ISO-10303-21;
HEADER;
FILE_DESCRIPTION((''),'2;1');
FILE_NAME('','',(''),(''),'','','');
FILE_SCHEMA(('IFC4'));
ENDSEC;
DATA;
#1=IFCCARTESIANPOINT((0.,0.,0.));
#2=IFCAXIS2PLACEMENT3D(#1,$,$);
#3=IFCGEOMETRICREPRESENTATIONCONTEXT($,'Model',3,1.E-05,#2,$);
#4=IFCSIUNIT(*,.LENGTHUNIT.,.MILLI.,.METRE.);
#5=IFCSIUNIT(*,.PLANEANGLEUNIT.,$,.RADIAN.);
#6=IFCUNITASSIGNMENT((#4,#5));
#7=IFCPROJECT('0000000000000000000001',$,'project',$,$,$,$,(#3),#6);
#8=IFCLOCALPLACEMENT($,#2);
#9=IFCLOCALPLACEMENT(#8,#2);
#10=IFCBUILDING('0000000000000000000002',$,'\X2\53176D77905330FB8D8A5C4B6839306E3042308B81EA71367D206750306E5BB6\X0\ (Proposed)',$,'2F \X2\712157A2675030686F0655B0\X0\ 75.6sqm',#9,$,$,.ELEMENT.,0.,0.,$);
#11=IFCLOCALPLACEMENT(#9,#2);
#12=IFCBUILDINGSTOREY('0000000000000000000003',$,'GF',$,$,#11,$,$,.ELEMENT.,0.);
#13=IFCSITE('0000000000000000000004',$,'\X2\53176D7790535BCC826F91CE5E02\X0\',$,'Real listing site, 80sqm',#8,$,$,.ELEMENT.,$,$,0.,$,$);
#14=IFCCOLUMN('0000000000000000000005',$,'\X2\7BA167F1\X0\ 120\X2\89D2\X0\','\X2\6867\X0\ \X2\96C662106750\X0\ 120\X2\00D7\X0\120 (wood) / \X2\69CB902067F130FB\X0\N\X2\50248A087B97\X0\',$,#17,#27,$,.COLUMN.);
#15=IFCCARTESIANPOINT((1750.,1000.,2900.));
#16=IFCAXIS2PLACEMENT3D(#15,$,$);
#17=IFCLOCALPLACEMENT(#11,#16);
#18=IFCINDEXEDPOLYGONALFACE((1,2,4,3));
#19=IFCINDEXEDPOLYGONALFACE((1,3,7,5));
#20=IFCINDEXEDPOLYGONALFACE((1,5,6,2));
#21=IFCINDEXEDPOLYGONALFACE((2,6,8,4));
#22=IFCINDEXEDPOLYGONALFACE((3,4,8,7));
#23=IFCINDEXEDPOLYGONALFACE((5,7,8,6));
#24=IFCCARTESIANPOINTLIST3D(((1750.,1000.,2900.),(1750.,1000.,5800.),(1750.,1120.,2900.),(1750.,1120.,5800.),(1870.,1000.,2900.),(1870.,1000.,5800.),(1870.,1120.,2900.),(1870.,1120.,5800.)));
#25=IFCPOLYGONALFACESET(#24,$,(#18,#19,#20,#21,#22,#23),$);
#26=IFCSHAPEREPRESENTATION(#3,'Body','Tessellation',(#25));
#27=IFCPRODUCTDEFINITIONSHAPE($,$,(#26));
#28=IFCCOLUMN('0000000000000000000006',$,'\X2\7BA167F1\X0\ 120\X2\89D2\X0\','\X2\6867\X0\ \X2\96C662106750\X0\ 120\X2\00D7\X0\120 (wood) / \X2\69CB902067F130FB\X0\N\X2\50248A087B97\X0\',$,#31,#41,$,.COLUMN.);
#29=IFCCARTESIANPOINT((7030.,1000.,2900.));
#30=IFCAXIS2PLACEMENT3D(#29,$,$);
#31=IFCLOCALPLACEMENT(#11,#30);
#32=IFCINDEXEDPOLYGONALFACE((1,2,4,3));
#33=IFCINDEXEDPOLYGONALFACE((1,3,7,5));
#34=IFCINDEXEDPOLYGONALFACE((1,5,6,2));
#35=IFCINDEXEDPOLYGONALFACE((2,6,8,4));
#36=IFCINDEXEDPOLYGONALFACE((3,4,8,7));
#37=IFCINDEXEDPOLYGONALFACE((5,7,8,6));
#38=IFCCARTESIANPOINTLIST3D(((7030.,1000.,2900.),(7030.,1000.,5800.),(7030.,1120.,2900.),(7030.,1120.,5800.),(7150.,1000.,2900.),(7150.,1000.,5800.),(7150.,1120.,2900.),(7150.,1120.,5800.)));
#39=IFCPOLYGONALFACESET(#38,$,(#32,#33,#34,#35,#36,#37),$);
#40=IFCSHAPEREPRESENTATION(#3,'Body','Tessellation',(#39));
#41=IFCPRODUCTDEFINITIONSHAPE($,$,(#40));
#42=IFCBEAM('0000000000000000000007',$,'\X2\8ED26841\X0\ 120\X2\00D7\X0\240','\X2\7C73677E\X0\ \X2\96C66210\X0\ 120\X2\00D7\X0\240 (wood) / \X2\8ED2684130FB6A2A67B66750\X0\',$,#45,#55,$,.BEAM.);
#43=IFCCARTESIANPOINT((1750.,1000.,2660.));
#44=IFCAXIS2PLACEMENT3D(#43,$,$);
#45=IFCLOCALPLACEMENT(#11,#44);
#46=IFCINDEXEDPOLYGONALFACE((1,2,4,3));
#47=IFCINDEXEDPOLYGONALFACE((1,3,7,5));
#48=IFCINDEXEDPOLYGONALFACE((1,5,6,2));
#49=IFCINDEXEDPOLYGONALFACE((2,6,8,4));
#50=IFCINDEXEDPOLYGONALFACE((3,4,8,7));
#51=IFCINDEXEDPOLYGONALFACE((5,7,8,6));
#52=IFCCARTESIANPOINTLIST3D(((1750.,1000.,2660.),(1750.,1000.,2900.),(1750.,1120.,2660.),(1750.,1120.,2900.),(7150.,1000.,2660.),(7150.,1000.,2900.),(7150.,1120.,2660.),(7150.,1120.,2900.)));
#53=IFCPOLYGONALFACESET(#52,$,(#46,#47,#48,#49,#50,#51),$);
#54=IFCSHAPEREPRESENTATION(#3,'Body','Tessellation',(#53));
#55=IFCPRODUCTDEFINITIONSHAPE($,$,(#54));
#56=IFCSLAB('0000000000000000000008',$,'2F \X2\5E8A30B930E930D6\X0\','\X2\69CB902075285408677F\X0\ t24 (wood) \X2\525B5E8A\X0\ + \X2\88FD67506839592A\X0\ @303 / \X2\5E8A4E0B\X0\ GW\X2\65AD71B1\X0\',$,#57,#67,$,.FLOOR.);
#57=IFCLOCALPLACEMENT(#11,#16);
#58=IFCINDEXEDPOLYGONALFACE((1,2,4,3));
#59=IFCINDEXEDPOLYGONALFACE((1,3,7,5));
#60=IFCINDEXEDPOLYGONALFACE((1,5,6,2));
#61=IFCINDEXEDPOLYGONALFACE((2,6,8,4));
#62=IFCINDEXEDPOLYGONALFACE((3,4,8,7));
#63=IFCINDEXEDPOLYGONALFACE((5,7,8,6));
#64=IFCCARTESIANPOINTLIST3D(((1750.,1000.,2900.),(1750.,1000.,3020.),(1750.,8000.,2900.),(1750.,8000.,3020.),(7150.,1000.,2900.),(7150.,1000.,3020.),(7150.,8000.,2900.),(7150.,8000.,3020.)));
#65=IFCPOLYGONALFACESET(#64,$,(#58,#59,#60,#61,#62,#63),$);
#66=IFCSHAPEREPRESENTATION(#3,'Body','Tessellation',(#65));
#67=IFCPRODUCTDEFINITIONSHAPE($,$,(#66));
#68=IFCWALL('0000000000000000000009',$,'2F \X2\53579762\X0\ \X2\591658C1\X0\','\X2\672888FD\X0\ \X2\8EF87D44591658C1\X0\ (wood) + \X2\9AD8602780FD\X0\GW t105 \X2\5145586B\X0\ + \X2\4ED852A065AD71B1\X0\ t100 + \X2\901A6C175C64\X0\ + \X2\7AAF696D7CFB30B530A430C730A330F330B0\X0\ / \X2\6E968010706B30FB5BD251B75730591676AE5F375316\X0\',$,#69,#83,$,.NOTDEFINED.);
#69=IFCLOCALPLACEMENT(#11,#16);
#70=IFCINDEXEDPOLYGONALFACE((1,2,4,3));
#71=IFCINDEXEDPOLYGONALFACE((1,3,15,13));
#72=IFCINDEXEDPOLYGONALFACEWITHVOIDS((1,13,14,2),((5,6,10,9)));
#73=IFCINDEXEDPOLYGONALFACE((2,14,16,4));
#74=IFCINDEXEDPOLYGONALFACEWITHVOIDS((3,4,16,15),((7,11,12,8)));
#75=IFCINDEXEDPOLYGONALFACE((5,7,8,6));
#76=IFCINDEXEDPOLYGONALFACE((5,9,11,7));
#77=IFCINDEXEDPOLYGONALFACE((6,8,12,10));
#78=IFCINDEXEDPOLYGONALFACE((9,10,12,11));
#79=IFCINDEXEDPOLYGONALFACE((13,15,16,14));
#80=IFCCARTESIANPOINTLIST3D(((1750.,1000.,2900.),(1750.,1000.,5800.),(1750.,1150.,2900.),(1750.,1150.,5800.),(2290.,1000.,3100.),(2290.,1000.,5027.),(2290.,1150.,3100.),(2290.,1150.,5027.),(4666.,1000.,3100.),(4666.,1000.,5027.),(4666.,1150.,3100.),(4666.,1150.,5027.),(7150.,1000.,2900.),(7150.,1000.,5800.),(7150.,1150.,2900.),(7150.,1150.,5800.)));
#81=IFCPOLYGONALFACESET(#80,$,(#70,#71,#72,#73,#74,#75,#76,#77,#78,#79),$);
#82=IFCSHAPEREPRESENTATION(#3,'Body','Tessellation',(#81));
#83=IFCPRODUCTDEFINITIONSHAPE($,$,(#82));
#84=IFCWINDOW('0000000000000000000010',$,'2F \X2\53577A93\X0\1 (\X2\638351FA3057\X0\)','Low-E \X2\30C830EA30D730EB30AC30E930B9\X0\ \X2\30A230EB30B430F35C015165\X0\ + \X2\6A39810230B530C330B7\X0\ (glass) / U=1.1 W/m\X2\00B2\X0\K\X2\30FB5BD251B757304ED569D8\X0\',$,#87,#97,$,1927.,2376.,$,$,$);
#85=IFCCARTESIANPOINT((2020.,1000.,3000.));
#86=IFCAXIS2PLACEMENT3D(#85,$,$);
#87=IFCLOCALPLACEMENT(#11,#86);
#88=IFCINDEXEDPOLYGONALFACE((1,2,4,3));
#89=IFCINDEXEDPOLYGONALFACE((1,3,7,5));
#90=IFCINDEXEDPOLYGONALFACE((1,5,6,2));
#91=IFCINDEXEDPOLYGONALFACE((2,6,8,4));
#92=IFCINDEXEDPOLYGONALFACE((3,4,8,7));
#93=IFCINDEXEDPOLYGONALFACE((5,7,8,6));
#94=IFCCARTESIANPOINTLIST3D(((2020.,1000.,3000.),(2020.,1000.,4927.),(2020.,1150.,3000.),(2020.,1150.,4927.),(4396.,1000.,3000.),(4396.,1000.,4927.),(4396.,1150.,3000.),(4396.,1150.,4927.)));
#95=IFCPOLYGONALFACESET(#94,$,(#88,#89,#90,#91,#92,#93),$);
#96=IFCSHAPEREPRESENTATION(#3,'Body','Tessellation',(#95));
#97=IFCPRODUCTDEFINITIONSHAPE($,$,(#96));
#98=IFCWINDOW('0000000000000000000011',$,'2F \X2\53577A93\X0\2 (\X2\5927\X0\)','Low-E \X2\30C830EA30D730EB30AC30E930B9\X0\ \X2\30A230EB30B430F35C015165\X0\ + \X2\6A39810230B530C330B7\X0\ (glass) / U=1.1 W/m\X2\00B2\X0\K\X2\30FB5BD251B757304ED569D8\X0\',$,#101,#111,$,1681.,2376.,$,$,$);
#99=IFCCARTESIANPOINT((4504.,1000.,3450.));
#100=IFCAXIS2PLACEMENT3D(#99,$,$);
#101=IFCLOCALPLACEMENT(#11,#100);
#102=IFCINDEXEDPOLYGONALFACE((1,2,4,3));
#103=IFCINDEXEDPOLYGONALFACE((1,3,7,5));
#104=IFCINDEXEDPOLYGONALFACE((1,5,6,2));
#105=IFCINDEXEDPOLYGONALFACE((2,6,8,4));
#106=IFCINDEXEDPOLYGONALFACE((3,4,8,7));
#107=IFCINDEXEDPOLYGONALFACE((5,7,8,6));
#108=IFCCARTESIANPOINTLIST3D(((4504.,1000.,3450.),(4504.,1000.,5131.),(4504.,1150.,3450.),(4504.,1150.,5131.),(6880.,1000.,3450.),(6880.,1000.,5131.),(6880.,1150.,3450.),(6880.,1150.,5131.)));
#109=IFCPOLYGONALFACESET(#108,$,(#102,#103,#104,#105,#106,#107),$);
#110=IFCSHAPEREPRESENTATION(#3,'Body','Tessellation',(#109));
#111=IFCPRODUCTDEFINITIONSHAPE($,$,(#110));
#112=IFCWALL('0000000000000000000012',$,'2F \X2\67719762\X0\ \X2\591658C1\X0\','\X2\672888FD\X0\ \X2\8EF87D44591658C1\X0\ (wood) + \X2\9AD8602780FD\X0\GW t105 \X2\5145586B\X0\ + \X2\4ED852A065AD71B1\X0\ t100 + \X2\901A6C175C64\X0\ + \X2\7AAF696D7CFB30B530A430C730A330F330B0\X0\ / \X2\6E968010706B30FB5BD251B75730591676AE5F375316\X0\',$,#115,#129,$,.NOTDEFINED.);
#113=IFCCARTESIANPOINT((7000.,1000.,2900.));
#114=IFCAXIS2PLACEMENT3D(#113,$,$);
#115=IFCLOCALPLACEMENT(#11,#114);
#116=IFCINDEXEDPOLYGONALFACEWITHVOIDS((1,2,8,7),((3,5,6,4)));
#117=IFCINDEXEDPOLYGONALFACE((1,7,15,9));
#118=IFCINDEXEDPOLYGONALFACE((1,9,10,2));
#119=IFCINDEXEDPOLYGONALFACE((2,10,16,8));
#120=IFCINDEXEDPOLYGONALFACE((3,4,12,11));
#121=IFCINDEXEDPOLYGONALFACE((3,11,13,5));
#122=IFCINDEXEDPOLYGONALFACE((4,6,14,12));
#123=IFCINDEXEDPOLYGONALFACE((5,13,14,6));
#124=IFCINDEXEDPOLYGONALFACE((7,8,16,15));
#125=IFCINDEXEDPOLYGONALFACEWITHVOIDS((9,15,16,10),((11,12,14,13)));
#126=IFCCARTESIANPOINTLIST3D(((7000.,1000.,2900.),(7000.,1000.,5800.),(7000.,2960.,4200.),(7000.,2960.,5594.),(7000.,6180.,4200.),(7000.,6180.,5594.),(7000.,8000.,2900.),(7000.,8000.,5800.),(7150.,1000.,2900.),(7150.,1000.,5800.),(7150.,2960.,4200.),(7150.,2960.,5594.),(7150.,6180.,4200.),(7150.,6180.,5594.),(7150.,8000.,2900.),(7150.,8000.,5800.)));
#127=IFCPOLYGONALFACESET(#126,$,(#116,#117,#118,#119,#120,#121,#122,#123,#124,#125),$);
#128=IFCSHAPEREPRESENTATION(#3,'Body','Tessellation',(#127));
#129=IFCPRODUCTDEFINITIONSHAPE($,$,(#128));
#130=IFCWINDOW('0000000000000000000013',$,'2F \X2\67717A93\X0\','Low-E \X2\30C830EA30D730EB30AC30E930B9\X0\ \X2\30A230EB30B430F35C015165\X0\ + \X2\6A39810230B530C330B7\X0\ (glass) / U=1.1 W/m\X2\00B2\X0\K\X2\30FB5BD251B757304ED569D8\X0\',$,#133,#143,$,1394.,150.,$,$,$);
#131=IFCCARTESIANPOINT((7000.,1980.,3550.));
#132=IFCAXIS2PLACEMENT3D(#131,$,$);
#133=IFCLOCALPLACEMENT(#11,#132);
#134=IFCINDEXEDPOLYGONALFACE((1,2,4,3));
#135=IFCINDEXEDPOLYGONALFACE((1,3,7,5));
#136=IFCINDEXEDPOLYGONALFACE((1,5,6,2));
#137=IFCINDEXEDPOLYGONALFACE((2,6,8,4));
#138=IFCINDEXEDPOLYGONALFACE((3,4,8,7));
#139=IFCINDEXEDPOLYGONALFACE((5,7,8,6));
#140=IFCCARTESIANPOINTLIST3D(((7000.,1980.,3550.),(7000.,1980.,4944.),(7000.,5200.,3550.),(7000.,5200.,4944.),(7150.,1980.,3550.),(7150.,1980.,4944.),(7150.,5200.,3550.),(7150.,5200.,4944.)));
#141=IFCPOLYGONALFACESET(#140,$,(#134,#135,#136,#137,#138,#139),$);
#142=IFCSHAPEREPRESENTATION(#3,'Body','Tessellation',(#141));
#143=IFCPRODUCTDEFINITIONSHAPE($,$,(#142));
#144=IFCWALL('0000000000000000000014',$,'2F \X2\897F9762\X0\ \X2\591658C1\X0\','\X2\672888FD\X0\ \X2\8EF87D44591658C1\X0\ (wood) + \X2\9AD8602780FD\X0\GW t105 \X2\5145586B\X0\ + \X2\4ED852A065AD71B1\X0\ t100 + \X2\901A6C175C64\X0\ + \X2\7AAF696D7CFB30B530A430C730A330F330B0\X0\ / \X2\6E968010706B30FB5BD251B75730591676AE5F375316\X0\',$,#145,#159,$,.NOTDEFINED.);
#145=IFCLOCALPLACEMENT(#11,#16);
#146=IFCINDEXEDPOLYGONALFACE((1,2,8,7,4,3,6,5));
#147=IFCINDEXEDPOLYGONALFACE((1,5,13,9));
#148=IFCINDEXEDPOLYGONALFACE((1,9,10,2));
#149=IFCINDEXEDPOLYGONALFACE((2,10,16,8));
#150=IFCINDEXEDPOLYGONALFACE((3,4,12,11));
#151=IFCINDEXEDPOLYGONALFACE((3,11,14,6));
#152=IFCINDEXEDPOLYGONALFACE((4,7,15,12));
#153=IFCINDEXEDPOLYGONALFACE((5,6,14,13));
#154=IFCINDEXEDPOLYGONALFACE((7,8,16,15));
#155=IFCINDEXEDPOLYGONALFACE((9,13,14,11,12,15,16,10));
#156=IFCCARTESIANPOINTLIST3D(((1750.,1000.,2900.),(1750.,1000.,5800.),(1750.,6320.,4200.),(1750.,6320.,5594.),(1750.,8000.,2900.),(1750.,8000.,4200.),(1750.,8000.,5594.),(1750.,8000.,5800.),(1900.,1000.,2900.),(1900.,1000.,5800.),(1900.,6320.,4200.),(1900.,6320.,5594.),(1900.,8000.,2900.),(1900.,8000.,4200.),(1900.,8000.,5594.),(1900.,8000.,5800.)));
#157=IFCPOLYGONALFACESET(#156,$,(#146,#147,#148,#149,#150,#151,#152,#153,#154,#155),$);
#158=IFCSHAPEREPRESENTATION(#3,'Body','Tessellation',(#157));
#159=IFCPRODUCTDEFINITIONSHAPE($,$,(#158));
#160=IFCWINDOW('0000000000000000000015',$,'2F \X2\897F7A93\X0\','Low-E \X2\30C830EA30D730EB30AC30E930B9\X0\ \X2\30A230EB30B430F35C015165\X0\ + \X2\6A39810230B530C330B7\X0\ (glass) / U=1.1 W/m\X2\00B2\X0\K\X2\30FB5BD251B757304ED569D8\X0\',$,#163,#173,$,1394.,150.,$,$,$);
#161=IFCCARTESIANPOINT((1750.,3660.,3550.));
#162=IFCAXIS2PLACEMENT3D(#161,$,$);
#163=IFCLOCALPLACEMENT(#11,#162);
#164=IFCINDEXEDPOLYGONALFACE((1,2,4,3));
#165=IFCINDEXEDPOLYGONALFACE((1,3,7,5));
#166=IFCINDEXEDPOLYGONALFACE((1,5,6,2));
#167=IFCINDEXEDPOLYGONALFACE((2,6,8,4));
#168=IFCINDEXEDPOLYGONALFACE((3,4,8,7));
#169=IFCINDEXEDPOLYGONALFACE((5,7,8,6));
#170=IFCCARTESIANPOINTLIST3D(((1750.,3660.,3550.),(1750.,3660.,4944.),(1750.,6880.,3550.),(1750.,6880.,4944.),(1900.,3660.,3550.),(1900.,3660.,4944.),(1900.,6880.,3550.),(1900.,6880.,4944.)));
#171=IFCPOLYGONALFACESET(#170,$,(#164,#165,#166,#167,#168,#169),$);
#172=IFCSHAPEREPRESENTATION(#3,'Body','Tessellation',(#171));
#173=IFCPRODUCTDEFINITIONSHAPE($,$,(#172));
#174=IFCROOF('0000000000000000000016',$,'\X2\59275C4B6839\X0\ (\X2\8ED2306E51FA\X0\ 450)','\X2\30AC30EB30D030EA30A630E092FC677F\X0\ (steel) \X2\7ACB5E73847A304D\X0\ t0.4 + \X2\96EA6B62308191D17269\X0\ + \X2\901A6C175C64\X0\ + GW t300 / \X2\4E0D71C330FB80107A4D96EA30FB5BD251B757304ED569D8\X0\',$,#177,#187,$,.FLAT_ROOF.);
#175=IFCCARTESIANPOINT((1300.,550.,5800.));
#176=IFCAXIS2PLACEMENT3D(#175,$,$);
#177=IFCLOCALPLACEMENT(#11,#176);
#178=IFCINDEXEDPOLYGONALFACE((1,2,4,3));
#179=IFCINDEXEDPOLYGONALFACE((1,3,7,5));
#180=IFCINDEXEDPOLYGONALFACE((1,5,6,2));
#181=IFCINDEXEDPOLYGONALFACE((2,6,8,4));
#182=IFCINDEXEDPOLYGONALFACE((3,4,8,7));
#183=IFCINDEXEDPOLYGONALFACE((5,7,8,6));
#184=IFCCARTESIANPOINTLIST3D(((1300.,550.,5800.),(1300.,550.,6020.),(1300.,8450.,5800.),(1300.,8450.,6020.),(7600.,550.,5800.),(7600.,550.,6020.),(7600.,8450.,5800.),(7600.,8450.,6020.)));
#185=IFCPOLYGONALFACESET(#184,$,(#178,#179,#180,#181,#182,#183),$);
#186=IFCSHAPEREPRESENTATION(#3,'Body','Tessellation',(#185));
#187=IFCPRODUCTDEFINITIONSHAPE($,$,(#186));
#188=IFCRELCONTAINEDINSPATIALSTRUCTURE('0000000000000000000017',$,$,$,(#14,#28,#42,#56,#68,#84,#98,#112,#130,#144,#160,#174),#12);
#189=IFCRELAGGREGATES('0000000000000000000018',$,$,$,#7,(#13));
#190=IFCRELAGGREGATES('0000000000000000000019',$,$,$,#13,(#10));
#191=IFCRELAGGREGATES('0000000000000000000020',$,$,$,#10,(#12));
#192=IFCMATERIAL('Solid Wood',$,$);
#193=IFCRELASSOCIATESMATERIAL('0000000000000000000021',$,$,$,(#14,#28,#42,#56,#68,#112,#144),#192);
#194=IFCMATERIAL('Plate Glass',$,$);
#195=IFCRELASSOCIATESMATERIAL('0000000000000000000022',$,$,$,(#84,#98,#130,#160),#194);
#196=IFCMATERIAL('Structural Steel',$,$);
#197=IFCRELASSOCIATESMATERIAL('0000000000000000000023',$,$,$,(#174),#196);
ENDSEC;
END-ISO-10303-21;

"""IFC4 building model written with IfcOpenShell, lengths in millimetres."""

from ifc_helpers import new_model, si_unit, frame, frame_2d, origin, place, context, project, spatial, rectangle, extrude, material, element, fill, save


model = new_model("IFC4")

# Units and contexts
model_context = context("Model", 3, precision=1e-05, world=origin())
ifc_project = project(units=[si_unit("LENGTHUNIT", "METRE", prefix="MILLI"), si_unit("PLANEANGLEUNIT", "RADIAN")], contexts=[model_context])

# Site, building, storey
site_placement = place(None, origin())
site = spatial("IfcSite", under=ifc_project, at=site_placement, Name="北海道富良野市", ObjectType="Real listing site, 80sqm", CompositionType="ELEMENT", RefElevation=0.0)
building_placement = place(site_placement, origin())
building = spatial("IfcBuilding", under=site, at=building_placement, Name="北海道・越屋根のある自然素材の家 (Proposed)", ObjectType="2F 無垢材と漆喰 75.6sqm", CompositionType="ELEMENT", ElevationOfRefHeight=0.0, ElevationOfTerrain=0.0)
storey_placement = place(building_placement, origin())
storey = spatial("IfcBuildingStorey", under=building, at=storey_placement, Name="GF", CompositionType="ELEMENT", Elevation=0.0)

# Columns
ifc_material_1 = material(Name="Solid Wood")
column_1_placement = place(storey_placement, frame((1750.0, 1000.0, 2900.0)))
element("IfcColumn", 1, at=column_1_placement, inside=storey, material=ifc_material_1, Name="管柱 120角", Description="桧 集成材 120×120 (wood) / 構造柱・N値計算", PredefinedType="COLUMN", context=model_context, shape_type="SweptSolid", body=[
    extrude(rectangle(XDim=120.0, YDim=120.0, at=frame_2d((60.0, 60.0))), frame((1750.0, 1000.0, 2900.0)), (0.0, 0.0, 1.0), 2900.0),
])
column_2_placement = place(storey_placement, frame((7030.0, 1000.0, 2900.0)))
element("IfcColumn", 2, at=column_2_placement, inside=storey, material=ifc_material_1, Name="管柱 120角", Description="桧 集成材 120×120 (wood) / 構造柱・N値計算", PredefinedType="COLUMN", context=model_context, shape_type="SweptSolid", body=[
    extrude(rectangle(XDim=120.0, YDim=120.0, at=frame_2d((60.0, 60.0))), frame((7030.0, 1000.0, 2900.0)), (0.0, 0.0, 1.0), 2900.0),
])

# Beam
beam_1_placement = place(storey_placement, frame((1750.0, 1000.0, 2660.0)))
element("IfcBeam", 3, at=beam_1_placement, inside=storey, material=ifc_material_1, Name="軒桁 120×240", Description="米松 集成 120×240 (wood) / 軒桁・横架材", PredefinedType="BEAM", context=model_context, shape_type="SweptSolid", body=[
    extrude(rectangle(XDim=5400.0, YDim=120.0, at=frame_2d((2700.0, 60.0))), frame((1750.0, 1000.0, 2660.0)), (0.0, 0.0, 1.0), 240.0),
])

# Slab
slab_placement = place(storey_placement, frame((1750.0, 1000.0, 2900.0)))
element("IfcSlab", 4, at=slab_placement, inside=storey, material=ifc_material_1, Name="2F 床スラブ", Description="構造用合板 t24 (wood) 剛床 + 製材根太 @303 / 床下 GW断熱", PredefinedType="FLOOR", context=model_context, shape_type="SweptSolid", body=[
    extrude(rectangle(XDim=5400.0, YDim=7000.0, at=frame_2d((2700.0, 3500.0))), frame((1750.0, 1000.0, 2900.0)), (0.0, 0.0, 1.0), 120.0),
])

# Wall, openings, windows
wall_1_placement = place(storey_placement, frame((1750.0, 1000.0, 2900.0)))
wall_1 = element("IfcWall", 5, at=wall_1_placement, inside=storey, material=ifc_material_1, Name="2F 南面 外壁", Description="木製 軸組外壁 (wood) + 高性能GW t105 充填 + 付加断熱 t100 + 通気層 + 窯業系サイディング / 準耐火・寒冷地外皮強化", PredefinedType="NOTDEFINED", context=model_context, shape_type="SweptSolid", body=[
    extrude(rectangle(XDim=5400.0, YDim=150.0, at=frame_2d((2700.0, 75.0))), frame((1750.0, 1000.0, 2900.0)), (0.0, 0.0, 1.0), 2900.0),
])
opening_1_placement = place(storey_placement, frame((2020.0, 1000.0, 3000.0)))
opening_1 = element("IfcOpeningElement", 6, at=opening_1_placement, cuts=wall_1, PredefinedType="NOTDEFINED", context=model_context, shape_type="SweptSolid", body=[
    extrude(rectangle(XDim=2376.0, YDim=150.0, at=frame_2d((1188.0, 75.0))), frame((2020.0, 1000.0, 3000.0)), (0.0, 0.0, 1.0), 1927.0),
])
opening_2_placement = place(storey_placement, frame((4504.0, 1000.0, 3450.0)))
opening_2 = element("IfcOpeningElement", 7, at=opening_2_placement, cuts=wall_1, PredefinedType="NOTDEFINED", context=model_context, shape_type="SweptSolid", body=[
    extrude(rectangle(XDim=2376.0, YDim=150.0, at=frame_2d((1188.0, 75.0))), frame((4504.0, 1000.0, 3450.0)), (0.0, 0.0, 1.0), 1681.0),
])
ifc_material_2 = material(Name="Plate Glass")
window_1_placement = place(storey_placement, frame((2020.0, 1000.0, 3000.0)))
window_1 = element("IfcWindow", 8, at=window_1_placement, inside=storey, material=ifc_material_2, Name="2F 南窓1 (掃出し)", Description="Low-E トリプルガラス アルゴン封入 + 樹脂サッシ (glass) / U=1.1 W/m²K・寒冷地仕様", OverallHeight=1927.0, OverallWidth=2376.0, context=model_context, shape_type="SweptSolid", body=[
    extrude(rectangle(XDim=2376.0, YDim=150.0, at=frame_2d((1188.0, 75.0))), frame((2020.0, 1000.0, 3000.0)), (0.0, 0.0, 1.0), 1927.0),
])
fill(opening_1, window_1)
window_2_placement = place(storey_placement, frame((4504.0, 1000.0, 3450.0)))
window_2 = element("IfcWindow", 9, at=window_2_placement, inside=storey, material=ifc_material_2, Name="2F 南窓2 (大)", Description="Low-E トリプルガラス アルゴン封入 + 樹脂サッシ (glass) / U=1.1 W/m²K・寒冷地仕様", OverallHeight=1681.0, OverallWidth=2376.0, context=model_context, shape_type="SweptSolid", body=[
    extrude(rectangle(XDim=2376.0, YDim=150.0, at=frame_2d((1188.0, 75.0))), frame((4504.0, 1000.0, 3450.0)), (0.0, 0.0, 1.0), 1681.0),
])
fill(opening_2, window_2)

# Walls, openings, windows
wall_2_placement = place(storey_placement, frame((7000.0, 1000.0, 2900.0)))
wall_2 = element("IfcWall", 10, at=wall_2_placement, inside=storey, material=ifc_material_1, Name="2F 東面 外壁", Description="木製 軸組外壁 (wood) + 高性能GW t105 充填 + 付加断熱 t100 + 通気層 + 窯業系サイディング / 準耐火・寒冷地外皮強化", PredefinedType="NOTDEFINED", context=model_context, shape_type="SweptSolid", body=[
    extrude(rectangle(XDim=150.0, YDim=7000.0, at=frame_2d((75.0, 3500.0))), frame((7000.0, 1000.0, 2900.0)), (0.0, 0.0, 1.0), 2900.0),
])
opening_3_placement = place(storey_placement, frame((7000.0, 1980.0, 3550.0)))
opening_3 = element("IfcOpeningElement", 11, at=opening_3_placement, cuts=wall_2, PredefinedType="NOTDEFINED", context=model_context, shape_type="SweptSolid", body=[
    extrude(rectangle(XDim=150.0, YDim=3220.0, at=frame_2d((75.0, 1610.0))), frame((7000.0, 1980.0, 3550.0)), (0.0, 0.0, 1.0), 1394.0),
])
window_3_placement = place(storey_placement, frame((7000.0, 1980.0, 3550.0)))
window_3 = element("IfcWindow", 12, at=window_3_placement, inside=storey, material=ifc_material_2, Name="2F 東窓", Description="Low-E トリプルガラス アルゴン封入 + 樹脂サッシ (glass) / U=1.1 W/m²K・寒冷地仕様", OverallHeight=1394.0, OverallWidth=150.0, context=model_context, shape_type="SweptSolid", body=[
    extrude(rectangle(XDim=150.0, YDim=3220.0, at=frame_2d((75.0, 1610.0))), frame((7000.0, 1980.0, 3550.0)), (0.0, 0.0, 1.0), 1394.0),
])
fill(opening_3, window_3)
wall_3_placement = place(storey_placement, frame((1750.0, 1000.0, 2900.0)))
wall_3 = element("IfcWall", 13, at=wall_3_placement, inside=storey, material=ifc_material_1, Name="2F 西面 外壁", Description="木製 軸組外壁 (wood) + 高性能GW t105 充填 + 付加断熱 t100 + 通気層 + 窯業系サイディング / 準耐火・寒冷地外皮強化", PredefinedType="NOTDEFINED", context=model_context, shape_type="SweptSolid", body=[
    extrude(rectangle(XDim=150.0, YDim=7000.0, at=frame_2d((75.0, 3500.0))), frame((1750.0, 1000.0, 2900.0)), (0.0, 0.0, 1.0), 2900.0),
])
opening_4_placement = place(storey_placement, frame((1750.0, 3660.0, 3550.0)))
opening_4 = element("IfcOpeningElement", 14, at=opening_4_placement, cuts=wall_3, PredefinedType="NOTDEFINED", context=model_context, shape_type="SweptSolid", body=[
    extrude(rectangle(XDim=150.0, YDim=3220.0, at=frame_2d((75.0, 1610.0))), frame((1750.0, 3660.0, 3550.0)), (0.0, 0.0, 1.0), 1394.0),
])
window_4_placement = place(storey_placement, frame((1750.0, 3660.0, 3550.0)))
window_4 = element("IfcWindow", 15, at=window_4_placement, inside=storey, material=ifc_material_2, Name="2F 西窓", Description="Low-E トリプルガラス アルゴン封入 + 樹脂サッシ (glass) / U=1.1 W/m²K・寒冷地仕様", OverallHeight=1394.0, OverallWidth=150.0, context=model_context, shape_type="SweptSolid", body=[
    extrude(rectangle(XDim=150.0, YDim=3220.0, at=frame_2d((75.0, 1610.0))), frame((1750.0, 3660.0, 3550.0)), (0.0, 0.0, 1.0), 1394.0),
])
fill(opening_4, window_4)

# Roof
ifc_material_3 = material(Name="Structural Steel")
roof_placement = place(storey_placement, frame((1300.0, 550.0, 5800.0)))
element("IfcRoof", 16, at=roof_placement, inside=storey, material=ifc_material_3, Name="大屋根 (軒の出 450)", Description="ガルバリウム鋼板 (steel) 立平葺き t0.4 + 雪止め金物 + 通気層 + GW t300 / 不燃・耐積雪・寒冷地仕様", PredefinedType="FLAT_ROOF", context=model_context, shape_type="SweptSolid", body=[
    extrude(rectangle(XDim=6300.0, YDim=7900.0, at=frame_2d((3150.0, 3950.0))), frame((1300.0, 550.0, 5800.0)), (0.0, 0.0, 1.0), 220.0),
])

save(model, "model.ifc")
